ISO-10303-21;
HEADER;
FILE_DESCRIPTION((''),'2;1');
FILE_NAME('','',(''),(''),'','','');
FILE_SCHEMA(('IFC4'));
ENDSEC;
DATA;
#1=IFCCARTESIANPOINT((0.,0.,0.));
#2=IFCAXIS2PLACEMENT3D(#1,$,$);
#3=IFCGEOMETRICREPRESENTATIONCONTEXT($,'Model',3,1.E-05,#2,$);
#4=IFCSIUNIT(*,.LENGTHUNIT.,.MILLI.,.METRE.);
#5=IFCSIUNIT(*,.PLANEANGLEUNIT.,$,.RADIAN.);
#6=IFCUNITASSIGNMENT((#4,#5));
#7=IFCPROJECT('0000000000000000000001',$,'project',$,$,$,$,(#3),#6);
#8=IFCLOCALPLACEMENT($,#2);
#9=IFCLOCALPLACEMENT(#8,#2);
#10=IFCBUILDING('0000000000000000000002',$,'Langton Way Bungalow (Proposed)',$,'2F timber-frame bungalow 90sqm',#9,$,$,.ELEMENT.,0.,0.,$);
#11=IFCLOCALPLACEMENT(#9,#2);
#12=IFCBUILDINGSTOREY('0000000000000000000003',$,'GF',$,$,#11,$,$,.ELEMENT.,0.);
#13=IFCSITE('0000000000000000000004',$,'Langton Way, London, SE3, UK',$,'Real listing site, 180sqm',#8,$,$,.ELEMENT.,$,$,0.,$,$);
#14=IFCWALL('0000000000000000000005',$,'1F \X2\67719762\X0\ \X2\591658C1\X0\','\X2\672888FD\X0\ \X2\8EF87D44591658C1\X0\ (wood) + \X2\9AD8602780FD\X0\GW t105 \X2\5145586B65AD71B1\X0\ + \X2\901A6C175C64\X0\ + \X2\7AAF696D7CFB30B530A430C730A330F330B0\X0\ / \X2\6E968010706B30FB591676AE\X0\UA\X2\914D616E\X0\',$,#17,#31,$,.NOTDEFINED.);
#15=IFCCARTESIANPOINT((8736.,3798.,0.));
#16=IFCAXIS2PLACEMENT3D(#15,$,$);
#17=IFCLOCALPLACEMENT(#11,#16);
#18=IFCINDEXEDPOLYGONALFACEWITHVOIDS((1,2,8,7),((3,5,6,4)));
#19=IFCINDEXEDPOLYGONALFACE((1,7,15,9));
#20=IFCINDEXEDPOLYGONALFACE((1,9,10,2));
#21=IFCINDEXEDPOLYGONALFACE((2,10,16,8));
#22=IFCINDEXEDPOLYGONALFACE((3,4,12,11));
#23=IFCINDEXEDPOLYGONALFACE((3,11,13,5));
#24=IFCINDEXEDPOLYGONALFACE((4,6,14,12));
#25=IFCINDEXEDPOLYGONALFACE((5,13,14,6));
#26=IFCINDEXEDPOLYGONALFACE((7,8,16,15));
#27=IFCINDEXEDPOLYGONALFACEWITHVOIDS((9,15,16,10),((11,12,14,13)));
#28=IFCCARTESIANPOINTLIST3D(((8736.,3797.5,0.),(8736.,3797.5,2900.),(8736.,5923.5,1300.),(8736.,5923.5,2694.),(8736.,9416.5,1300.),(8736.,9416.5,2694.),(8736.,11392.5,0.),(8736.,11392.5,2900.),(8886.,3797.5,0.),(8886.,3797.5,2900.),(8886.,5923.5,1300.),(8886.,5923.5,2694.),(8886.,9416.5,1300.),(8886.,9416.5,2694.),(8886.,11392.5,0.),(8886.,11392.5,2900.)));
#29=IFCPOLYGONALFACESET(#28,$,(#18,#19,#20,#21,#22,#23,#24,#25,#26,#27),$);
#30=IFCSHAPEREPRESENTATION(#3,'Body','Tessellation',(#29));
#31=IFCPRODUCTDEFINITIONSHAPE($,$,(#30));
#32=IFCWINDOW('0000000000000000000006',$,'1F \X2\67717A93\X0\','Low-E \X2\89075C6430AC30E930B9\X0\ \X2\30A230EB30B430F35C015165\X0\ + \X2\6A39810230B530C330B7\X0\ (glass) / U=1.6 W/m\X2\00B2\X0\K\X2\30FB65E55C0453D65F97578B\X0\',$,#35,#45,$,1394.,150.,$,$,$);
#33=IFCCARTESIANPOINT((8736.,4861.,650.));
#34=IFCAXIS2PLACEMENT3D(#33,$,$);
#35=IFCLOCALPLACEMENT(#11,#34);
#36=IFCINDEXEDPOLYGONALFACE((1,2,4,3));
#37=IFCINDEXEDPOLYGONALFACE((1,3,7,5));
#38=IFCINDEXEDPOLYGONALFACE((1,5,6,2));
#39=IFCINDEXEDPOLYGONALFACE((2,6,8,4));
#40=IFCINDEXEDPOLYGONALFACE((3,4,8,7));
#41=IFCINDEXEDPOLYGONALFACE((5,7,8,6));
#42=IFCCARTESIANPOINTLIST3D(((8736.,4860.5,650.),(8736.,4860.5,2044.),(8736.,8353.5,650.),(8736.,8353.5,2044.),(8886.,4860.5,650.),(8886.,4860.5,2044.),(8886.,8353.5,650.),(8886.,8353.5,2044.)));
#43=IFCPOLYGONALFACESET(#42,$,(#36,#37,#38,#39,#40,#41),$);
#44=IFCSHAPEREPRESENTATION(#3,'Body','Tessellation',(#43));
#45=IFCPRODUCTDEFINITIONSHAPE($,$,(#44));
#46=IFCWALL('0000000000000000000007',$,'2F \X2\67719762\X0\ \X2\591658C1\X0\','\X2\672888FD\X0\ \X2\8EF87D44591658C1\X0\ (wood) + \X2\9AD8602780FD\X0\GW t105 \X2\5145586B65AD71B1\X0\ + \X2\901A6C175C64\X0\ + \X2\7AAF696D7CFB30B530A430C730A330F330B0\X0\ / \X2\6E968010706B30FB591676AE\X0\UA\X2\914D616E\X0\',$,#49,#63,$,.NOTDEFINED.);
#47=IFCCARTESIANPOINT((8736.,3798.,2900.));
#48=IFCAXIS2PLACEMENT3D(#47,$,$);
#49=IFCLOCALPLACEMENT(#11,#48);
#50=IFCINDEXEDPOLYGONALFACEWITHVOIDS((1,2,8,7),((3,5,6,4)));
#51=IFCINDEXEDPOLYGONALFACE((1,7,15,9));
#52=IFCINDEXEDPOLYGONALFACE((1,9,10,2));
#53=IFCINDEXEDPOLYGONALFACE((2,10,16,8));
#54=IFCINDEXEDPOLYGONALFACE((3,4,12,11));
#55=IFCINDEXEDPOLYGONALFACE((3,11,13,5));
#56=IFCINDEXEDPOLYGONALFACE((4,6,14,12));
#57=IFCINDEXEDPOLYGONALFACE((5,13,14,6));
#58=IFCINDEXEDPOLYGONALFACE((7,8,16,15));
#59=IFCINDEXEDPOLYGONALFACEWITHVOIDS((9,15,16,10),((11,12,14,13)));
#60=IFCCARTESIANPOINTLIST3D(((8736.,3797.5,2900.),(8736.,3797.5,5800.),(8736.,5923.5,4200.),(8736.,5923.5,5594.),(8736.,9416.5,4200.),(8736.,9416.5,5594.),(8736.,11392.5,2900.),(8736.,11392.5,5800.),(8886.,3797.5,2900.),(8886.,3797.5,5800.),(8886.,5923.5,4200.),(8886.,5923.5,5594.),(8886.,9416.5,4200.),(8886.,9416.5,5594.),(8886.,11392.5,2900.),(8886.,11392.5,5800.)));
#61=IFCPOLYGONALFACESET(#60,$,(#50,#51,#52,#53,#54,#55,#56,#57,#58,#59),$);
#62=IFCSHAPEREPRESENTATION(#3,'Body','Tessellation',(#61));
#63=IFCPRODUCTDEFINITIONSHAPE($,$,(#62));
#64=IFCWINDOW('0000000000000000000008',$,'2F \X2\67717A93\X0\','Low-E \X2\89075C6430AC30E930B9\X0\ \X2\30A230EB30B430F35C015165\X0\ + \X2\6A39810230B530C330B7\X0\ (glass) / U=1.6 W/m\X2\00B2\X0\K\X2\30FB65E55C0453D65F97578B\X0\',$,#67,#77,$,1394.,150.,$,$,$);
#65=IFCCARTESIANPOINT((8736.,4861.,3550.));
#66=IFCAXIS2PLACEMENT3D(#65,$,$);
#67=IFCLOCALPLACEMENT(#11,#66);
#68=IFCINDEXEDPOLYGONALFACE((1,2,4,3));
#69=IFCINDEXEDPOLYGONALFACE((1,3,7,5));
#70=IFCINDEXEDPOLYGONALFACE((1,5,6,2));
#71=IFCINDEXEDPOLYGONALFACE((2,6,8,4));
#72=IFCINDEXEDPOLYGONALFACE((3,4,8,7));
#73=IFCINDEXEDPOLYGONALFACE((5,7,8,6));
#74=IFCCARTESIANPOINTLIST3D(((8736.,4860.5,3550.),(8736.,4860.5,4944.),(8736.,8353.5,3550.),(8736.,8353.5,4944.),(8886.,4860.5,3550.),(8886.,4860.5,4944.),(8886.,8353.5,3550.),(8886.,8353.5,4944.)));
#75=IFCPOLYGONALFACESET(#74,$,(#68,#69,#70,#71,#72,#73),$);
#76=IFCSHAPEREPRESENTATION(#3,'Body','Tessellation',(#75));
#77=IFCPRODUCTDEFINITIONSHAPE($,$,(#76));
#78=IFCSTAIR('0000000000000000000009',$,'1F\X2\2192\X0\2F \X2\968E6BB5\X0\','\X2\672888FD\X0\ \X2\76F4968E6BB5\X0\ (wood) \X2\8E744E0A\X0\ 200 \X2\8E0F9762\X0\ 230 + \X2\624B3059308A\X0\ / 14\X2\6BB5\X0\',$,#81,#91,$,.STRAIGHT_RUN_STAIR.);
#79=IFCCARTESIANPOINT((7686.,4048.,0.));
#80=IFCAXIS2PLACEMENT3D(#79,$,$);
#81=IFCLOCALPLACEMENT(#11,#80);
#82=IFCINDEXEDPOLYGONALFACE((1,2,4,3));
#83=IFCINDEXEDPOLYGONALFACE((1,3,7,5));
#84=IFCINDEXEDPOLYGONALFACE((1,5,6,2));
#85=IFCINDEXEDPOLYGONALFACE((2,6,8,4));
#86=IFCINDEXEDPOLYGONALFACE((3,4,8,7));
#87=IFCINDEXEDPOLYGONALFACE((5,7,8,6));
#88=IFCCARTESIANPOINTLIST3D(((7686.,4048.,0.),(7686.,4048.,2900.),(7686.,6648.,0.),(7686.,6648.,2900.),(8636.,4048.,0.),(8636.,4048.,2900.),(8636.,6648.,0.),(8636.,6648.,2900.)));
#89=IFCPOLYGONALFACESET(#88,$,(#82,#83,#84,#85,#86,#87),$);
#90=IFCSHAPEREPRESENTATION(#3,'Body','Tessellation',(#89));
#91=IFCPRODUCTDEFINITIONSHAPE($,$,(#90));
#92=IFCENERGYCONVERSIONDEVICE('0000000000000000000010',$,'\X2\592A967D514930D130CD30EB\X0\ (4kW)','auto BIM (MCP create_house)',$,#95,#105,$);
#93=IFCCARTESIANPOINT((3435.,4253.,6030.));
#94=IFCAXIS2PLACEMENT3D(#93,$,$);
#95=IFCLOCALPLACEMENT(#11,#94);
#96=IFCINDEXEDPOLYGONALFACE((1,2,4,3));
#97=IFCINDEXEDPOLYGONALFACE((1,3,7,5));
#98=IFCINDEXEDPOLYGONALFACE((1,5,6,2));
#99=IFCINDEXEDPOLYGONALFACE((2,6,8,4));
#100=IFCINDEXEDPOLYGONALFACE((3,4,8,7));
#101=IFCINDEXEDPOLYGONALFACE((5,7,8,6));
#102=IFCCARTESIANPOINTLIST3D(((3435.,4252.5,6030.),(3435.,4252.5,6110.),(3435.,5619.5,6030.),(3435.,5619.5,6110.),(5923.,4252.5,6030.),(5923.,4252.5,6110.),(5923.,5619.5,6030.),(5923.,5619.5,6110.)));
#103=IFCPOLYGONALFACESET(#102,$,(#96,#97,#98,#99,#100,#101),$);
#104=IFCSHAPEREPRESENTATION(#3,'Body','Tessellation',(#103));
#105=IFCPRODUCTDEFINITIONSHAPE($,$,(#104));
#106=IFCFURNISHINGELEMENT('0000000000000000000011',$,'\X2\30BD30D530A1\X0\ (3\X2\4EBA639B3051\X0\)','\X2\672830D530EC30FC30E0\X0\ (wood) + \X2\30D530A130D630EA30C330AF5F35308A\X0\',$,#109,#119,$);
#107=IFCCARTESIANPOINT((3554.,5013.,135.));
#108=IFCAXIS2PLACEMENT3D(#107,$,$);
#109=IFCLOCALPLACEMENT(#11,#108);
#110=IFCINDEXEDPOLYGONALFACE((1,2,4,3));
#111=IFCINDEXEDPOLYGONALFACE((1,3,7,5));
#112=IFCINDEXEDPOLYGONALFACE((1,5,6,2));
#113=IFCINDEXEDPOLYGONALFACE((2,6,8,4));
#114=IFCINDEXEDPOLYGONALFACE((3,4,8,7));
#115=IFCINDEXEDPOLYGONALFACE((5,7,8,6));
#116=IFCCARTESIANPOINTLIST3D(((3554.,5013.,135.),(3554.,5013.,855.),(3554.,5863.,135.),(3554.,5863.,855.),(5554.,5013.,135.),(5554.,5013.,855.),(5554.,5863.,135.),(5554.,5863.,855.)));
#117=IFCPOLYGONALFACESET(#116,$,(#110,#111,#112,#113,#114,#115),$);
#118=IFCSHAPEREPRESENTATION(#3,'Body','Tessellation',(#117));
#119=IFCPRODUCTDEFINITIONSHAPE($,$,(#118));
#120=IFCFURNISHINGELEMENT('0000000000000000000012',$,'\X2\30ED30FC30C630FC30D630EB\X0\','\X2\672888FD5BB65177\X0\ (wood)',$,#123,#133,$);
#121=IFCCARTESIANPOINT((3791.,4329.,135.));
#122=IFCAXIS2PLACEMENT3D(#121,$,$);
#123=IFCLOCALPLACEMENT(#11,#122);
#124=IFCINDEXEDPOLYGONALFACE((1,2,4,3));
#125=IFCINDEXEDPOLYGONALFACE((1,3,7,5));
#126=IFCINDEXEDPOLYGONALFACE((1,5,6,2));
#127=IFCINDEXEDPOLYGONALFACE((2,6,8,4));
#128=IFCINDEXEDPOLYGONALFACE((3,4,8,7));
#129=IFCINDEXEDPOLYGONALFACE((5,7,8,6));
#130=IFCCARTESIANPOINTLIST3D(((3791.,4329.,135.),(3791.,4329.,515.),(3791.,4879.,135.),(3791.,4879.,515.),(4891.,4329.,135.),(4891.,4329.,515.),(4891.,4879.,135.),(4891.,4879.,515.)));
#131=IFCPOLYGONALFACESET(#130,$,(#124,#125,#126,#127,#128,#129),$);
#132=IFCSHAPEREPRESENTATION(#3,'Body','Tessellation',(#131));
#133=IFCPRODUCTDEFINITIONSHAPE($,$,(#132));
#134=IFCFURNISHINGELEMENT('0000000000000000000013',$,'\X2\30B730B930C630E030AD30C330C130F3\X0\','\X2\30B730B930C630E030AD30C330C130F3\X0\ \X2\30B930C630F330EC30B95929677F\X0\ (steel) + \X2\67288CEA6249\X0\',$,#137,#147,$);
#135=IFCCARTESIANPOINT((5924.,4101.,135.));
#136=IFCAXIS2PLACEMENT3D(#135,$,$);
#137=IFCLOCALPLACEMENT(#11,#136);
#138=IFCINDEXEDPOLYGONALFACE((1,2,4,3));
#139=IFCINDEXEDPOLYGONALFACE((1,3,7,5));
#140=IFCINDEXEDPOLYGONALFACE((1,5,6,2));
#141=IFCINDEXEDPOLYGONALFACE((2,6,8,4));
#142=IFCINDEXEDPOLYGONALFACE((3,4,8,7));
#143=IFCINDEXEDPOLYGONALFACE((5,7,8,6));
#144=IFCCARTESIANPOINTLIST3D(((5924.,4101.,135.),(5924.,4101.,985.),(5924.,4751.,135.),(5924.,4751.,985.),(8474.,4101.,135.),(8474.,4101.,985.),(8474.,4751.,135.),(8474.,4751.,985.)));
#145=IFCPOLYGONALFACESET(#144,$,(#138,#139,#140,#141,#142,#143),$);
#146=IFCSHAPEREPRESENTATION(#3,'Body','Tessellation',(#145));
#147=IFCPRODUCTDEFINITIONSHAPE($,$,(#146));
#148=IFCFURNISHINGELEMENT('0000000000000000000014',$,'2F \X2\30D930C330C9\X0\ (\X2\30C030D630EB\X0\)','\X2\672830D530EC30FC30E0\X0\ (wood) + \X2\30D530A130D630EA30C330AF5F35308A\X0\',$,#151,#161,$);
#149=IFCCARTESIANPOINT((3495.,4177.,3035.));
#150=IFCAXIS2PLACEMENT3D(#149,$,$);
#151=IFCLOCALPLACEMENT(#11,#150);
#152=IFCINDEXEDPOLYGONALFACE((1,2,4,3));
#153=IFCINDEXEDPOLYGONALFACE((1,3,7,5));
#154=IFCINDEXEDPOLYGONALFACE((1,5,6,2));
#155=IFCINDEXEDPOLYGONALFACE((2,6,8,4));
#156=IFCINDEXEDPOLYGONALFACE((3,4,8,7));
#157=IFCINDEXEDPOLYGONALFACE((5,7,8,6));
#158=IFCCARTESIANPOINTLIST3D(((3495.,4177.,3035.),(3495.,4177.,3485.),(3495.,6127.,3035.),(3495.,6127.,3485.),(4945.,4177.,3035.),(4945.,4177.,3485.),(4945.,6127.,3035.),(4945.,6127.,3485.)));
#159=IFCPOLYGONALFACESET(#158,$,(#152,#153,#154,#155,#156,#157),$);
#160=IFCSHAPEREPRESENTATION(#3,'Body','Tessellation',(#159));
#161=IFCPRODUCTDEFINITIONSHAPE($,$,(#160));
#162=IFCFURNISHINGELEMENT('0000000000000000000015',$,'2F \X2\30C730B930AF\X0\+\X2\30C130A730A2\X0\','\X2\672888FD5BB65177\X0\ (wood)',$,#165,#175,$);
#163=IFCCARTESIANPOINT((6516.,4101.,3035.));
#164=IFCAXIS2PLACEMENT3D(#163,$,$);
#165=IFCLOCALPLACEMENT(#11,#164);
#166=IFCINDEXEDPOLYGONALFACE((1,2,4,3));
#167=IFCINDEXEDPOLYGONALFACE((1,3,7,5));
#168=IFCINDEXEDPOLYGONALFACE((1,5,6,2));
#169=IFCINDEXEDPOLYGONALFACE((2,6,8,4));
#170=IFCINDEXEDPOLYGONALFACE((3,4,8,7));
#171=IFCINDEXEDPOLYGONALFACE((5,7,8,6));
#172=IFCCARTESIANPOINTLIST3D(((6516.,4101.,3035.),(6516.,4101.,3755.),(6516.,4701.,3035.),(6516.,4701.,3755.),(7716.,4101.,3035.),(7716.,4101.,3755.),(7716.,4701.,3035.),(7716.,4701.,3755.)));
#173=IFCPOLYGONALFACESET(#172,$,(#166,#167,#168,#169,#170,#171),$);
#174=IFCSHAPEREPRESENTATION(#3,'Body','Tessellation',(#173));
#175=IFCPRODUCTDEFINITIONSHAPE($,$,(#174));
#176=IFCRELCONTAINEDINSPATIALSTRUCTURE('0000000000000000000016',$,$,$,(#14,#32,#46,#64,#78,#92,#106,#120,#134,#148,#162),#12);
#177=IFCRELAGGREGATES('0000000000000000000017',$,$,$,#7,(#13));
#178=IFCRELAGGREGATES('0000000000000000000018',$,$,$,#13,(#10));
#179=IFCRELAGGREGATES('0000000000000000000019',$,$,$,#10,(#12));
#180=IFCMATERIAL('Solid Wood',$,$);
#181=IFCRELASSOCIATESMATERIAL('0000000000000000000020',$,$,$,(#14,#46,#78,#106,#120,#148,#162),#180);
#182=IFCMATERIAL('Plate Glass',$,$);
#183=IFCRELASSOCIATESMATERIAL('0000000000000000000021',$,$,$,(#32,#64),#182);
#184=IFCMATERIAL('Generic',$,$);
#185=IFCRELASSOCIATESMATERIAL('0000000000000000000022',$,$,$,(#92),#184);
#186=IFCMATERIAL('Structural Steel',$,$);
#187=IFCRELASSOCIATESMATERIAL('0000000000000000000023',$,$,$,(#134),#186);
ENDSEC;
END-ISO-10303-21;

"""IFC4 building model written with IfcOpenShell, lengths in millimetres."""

from ifc_helpers import new_model, si_unit, frame, frame_2d, origin, place, context, project, spatial, rectangle, extrude, material, element, fill, save


model = new_model("IFC4")

# Units and contexts
model_context = context("Model", 3, precision=1e-05, world=origin())
ifc_project = project(units=[si_unit("LENGTHUNIT", "METRE", prefix="MILLI"), si_unit("PLANEANGLEUNIT", "RADIAN")], contexts=[model_context])

# Site, building, storey
site_placement = place(None, origin())
site = spatial("IfcSite", under=ifc_project, at=site_placement, Name="Langton Way, London, SE3, UK", ObjectType="Real listing site, 180sqm", CompositionType="ELEMENT", RefElevation=0.0)
building_placement = place(site_placement, origin())
building = spatial("IfcBuilding", under=site, at=building_placement, Name="Langton Way Bungalow (Proposed)", ObjectType="2F timber-frame bungalow 90sqm", CompositionType="ELEMENT", ElevationOfRefHeight=0.0, ElevationOfTerrain=0.0)
storey_placement = place(building_placement, origin())
storey = spatial("IfcBuildingStorey", under=building, at=storey_placement, Name="GF", CompositionType="ELEMENT", Elevation=0.0)

# Wall, opening, window
ifc_material_1 = material(Name="Solid Wood")
wall_1_placement = place(storey_placement, frame((8736.0, 3798.0, 0.0)))
wall_1 = element("IfcWall", 1, at=wall_1_placement, inside=storey, material=ifc_material_1, Name="1F 東面 外壁", Description="木製 軸組外壁 (wood) + 高性能GW t105 充填断熱 + 通気層 + 窯業系サイディング / 準耐火・外皮UA配慮", PredefinedType="NOTDEFINED", context=model_context, shape_type="SweptSolid", body=[
    extrude(rectangle(XDim=150.0, YDim=7595.0, at=frame_2d((75.0, 3797.0))), frame((8736.0, 3798.0, 0.0)), (0.0, 0.0, 1.0), 2900.0),
])
opening_1_placement = place(storey_placement, frame((8736.0, 4861.0, 650.0)))
opening_1 = element("IfcOpeningElement", 2, at=opening_1_placement, cuts=wall_1, PredefinedType="NOTDEFINED", context=model_context, shape_type="SweptSolid", body=[
    extrude(rectangle(XDim=150.0, YDim=3493.0, at=frame_2d((75.0, 1746.0))), frame((8736.0, 4861.0, 650.0)), (0.0, 0.0, 1.0), 1394.0),
])
ifc_material_2 = material(Name="Plate Glass")
window_1_placement = place(storey_placement, frame((8736.0, 4861.0, 650.0)))
window_1 = element("IfcWindow", 3, at=window_1_placement, inside=storey, material=ifc_material_2, Name="1F 東窓", Description="Low-E 複層ガラス アルゴン封入 + 樹脂サッシ (glass) / U=1.6 W/m²K・日射取得型", OverallHeight=1394.0, OverallWidth=150.0, context=model_context, shape_type="SweptSolid", body=[
    extrude(rectangle(XDim=150.0, YDim=3493.0, at=frame_2d((75.0, 1746.0))), frame((8736.0, 4861.0, 650.0)), (0.0, 0.0, 1.0), 1394.0),
])
fill(opening_1, window_1)

# Wall, opening, window
wall_2_placement = place(storey_placement, frame((8736.0, 3798.0, 2900.0)))
wall_2 = element("IfcWall", 4, at=wall_2_placement, inside=storey, material=ifc_material_1, Name="2F 東面 外壁", Description="木製 軸組外壁 (wood) + 高性能GW t105 充填断熱 + 通気層 + 窯業系サイディング / 準耐火・外皮UA配慮", PredefinedType="NOTDEFINED", context=model_context, shape_type="SweptSolid", body=[
    extrude(rectangle(XDim=150.0, YDim=7595.0, at=frame_2d((75.0, 3797.0))), frame((8736.0, 3798.0, 2900.0)), (0.0, 0.0, 1.0), 2900.0),
])
opening_2_placement = place(storey_placement, frame((8736.0, 4861.0, 3550.0)))
opening_2 = element("IfcOpeningElement", 5, at=opening_2_placement, cuts=wall_2, PredefinedType="NOTDEFINED", context=model_context, shape_type="SweptSolid", body=[
    extrude(rectangle(XDim=150.0, YDim=3493.0, at=frame_2d((75.0, 1746.0))), frame((8736.0, 4861.0, 3550.0)), (0.0, 0.0, 1.0), 1394.0),
])
window_2_placement = place(storey_placement, frame((8736.0, 4861.0, 3550.0)))
window_2 = element("IfcWindow", 6, at=window_2_placement, inside=storey, material=ifc_material_2, Name="2F 東窓", Description="Low-E 複層ガラス アルゴン封入 + 樹脂サッシ (glass) / U=1.6 W/m²K・日射取得型", OverallHeight=1394.0, OverallWidth=150.0, context=model_context, shape_type="SweptSolid", body=[
    extrude(rectangle(XDim=150.0, YDim=3493.0, at=frame_2d((75.0, 1746.0))), frame((8736.0, 4861.0, 3550.0)), (0.0, 0.0, 1.0), 1394.0),
])
fill(opening_2, window_2)

# Stair
stair_placement = place(storey_placement, frame((7686.0, 4048.0, 0.0)))
element("IfcStair", 7, at=stair_placement, inside=storey, material=ifc_material_1, Name="1F→2F 階段", Description="木製 直階段 (wood) 蹴上 200 踏面 230 + 手すり / 14段", PredefinedType="STRAIGHT_RUN_STAIR", context=model_context, shape_type="SweptSolid", body=[
    extrude(rectangle(XDim=950.0, YDim=2600.0, at=frame_2d((475.0, 1300.0))), frame((7686.0, 4048.0, 0.0)), (0.0, 0.0, 1.0), 2900.0),
])

# Energy conversion device
ifc_material_3 = material(Name="Generic")
energy_conversion_device_placement = place(storey_placement, frame((3435.0, 4253.0, 6030.0)))
element("IfcEnergyConversionDevice", 8, at=energy_conversion_device_placement, inside=storey, material=ifc_material_3, Name="太陽光パネル (4kW)", Description="auto BIM (MCP create_house)", context=model_context, shape_type="SweptSolid", body=[
    extrude(rectangle(XDim=2488.0, YDim=1367.0, at=frame_2d((1244.0, 683.0))), frame((3435.0, 4253.0, 6030.0)), (0.0, 0.0, 1.0), 80.0),
])

# Furnishing elements
furnishing_1_placement = place(storey_placement, frame((3554.0, 5013.0, 135.0)))
element("IfcFurnishingElement", 9, at=furnishing_1_placement, inside=storey, material=ifc_material_1, Name="ソファ (3人掛け)", Description="木フレーム (wood) + ファブリック張り", context=model_context, shape_type="SweptSolid", body=[
    extrude(rectangle(XDim=2000.0, YDim=850.0, at=frame_2d((1000.0, 425.0))), frame((3554.0, 5013.0, 135.0)), (0.0, 0.0, 1.0), 720.0),
])
furnishing_2_placement = place(storey_placement, frame((3791.0, 4329.0, 135.0)))
element("IfcFurnishingElement", 10, at=furnishing_2_placement, inside=storey, material=ifc_material_1, Name="ローテーブル", Description="木製家具 (wood)", context=model_context, shape_type="SweptSolid", body=[
    extrude(rectangle(XDim=1100.0, YDim=550.0, at=frame_2d((550.0, 275.0))), frame((3791.0, 4329.0, 135.0)), (0.0, 0.0, 1.0), 380.0),
])
ifc_material_4 = material(Name="Structural Steel")
furnishing_3_placement = place(storey_placement, frame((5924.0, 4101.0, 135.0)))
element("IfcFurnishingElement", 11, at=furnishing_3_placement, inside=storey, material=ifc_material_4, Name="システムキッチン", Description="システムキッチン ステンレス天板 (steel) + 木質扉", context=model_context, shape_type="SweptSolid", body=[
    extrude(rectangle(XDim=2550.0, YDim=650.0, at=frame_2d((1275.0, 325.0))), frame((5924.0, 4101.0, 135.0)), (0.0, 0.0, 1.0), 850.0),
])
furnishing_4_placement = place(storey_placement, frame((3495.0, 4177.0, 3035.0)))
element("IfcFurnishingElement", 12, at=furnishing_4_placement, inside=storey, material=ifc_material_1, Name="2F ベッド (ダブル)", Description="木フレーム (wood) + ファブリック張り", context=model_context, shape_type="SweptSolid", body=[
    extrude(rectangle(XDim=1450.0, YDim=1950.0, at=frame_2d((725.0, 975.0))), frame((3495.0, 4177.0, 3035.0)), (0.0, 0.0, 1.0), 450.0),
])
furnishing_5_placement = place(storey_placement, frame((6516.0, 4101.0, 3035.0)))
element("IfcFurnishingElement", 13, at=furnishing_5_placement, inside=storey, material=ifc_material_1, Name="2F デスク+チェア", Description="木製家具 (wood)", context=model_context, shape_type="SweptSolid", body=[
    extrude(rectangle(XDim=1200.0, YDim=600.0, at=frame_2d((600.0, 300.0))), frame((6516.0, 4101.0, 3035.0)), (0.0, 0.0, 1.0), 720.0),
])

save(model, "model.ifc")
